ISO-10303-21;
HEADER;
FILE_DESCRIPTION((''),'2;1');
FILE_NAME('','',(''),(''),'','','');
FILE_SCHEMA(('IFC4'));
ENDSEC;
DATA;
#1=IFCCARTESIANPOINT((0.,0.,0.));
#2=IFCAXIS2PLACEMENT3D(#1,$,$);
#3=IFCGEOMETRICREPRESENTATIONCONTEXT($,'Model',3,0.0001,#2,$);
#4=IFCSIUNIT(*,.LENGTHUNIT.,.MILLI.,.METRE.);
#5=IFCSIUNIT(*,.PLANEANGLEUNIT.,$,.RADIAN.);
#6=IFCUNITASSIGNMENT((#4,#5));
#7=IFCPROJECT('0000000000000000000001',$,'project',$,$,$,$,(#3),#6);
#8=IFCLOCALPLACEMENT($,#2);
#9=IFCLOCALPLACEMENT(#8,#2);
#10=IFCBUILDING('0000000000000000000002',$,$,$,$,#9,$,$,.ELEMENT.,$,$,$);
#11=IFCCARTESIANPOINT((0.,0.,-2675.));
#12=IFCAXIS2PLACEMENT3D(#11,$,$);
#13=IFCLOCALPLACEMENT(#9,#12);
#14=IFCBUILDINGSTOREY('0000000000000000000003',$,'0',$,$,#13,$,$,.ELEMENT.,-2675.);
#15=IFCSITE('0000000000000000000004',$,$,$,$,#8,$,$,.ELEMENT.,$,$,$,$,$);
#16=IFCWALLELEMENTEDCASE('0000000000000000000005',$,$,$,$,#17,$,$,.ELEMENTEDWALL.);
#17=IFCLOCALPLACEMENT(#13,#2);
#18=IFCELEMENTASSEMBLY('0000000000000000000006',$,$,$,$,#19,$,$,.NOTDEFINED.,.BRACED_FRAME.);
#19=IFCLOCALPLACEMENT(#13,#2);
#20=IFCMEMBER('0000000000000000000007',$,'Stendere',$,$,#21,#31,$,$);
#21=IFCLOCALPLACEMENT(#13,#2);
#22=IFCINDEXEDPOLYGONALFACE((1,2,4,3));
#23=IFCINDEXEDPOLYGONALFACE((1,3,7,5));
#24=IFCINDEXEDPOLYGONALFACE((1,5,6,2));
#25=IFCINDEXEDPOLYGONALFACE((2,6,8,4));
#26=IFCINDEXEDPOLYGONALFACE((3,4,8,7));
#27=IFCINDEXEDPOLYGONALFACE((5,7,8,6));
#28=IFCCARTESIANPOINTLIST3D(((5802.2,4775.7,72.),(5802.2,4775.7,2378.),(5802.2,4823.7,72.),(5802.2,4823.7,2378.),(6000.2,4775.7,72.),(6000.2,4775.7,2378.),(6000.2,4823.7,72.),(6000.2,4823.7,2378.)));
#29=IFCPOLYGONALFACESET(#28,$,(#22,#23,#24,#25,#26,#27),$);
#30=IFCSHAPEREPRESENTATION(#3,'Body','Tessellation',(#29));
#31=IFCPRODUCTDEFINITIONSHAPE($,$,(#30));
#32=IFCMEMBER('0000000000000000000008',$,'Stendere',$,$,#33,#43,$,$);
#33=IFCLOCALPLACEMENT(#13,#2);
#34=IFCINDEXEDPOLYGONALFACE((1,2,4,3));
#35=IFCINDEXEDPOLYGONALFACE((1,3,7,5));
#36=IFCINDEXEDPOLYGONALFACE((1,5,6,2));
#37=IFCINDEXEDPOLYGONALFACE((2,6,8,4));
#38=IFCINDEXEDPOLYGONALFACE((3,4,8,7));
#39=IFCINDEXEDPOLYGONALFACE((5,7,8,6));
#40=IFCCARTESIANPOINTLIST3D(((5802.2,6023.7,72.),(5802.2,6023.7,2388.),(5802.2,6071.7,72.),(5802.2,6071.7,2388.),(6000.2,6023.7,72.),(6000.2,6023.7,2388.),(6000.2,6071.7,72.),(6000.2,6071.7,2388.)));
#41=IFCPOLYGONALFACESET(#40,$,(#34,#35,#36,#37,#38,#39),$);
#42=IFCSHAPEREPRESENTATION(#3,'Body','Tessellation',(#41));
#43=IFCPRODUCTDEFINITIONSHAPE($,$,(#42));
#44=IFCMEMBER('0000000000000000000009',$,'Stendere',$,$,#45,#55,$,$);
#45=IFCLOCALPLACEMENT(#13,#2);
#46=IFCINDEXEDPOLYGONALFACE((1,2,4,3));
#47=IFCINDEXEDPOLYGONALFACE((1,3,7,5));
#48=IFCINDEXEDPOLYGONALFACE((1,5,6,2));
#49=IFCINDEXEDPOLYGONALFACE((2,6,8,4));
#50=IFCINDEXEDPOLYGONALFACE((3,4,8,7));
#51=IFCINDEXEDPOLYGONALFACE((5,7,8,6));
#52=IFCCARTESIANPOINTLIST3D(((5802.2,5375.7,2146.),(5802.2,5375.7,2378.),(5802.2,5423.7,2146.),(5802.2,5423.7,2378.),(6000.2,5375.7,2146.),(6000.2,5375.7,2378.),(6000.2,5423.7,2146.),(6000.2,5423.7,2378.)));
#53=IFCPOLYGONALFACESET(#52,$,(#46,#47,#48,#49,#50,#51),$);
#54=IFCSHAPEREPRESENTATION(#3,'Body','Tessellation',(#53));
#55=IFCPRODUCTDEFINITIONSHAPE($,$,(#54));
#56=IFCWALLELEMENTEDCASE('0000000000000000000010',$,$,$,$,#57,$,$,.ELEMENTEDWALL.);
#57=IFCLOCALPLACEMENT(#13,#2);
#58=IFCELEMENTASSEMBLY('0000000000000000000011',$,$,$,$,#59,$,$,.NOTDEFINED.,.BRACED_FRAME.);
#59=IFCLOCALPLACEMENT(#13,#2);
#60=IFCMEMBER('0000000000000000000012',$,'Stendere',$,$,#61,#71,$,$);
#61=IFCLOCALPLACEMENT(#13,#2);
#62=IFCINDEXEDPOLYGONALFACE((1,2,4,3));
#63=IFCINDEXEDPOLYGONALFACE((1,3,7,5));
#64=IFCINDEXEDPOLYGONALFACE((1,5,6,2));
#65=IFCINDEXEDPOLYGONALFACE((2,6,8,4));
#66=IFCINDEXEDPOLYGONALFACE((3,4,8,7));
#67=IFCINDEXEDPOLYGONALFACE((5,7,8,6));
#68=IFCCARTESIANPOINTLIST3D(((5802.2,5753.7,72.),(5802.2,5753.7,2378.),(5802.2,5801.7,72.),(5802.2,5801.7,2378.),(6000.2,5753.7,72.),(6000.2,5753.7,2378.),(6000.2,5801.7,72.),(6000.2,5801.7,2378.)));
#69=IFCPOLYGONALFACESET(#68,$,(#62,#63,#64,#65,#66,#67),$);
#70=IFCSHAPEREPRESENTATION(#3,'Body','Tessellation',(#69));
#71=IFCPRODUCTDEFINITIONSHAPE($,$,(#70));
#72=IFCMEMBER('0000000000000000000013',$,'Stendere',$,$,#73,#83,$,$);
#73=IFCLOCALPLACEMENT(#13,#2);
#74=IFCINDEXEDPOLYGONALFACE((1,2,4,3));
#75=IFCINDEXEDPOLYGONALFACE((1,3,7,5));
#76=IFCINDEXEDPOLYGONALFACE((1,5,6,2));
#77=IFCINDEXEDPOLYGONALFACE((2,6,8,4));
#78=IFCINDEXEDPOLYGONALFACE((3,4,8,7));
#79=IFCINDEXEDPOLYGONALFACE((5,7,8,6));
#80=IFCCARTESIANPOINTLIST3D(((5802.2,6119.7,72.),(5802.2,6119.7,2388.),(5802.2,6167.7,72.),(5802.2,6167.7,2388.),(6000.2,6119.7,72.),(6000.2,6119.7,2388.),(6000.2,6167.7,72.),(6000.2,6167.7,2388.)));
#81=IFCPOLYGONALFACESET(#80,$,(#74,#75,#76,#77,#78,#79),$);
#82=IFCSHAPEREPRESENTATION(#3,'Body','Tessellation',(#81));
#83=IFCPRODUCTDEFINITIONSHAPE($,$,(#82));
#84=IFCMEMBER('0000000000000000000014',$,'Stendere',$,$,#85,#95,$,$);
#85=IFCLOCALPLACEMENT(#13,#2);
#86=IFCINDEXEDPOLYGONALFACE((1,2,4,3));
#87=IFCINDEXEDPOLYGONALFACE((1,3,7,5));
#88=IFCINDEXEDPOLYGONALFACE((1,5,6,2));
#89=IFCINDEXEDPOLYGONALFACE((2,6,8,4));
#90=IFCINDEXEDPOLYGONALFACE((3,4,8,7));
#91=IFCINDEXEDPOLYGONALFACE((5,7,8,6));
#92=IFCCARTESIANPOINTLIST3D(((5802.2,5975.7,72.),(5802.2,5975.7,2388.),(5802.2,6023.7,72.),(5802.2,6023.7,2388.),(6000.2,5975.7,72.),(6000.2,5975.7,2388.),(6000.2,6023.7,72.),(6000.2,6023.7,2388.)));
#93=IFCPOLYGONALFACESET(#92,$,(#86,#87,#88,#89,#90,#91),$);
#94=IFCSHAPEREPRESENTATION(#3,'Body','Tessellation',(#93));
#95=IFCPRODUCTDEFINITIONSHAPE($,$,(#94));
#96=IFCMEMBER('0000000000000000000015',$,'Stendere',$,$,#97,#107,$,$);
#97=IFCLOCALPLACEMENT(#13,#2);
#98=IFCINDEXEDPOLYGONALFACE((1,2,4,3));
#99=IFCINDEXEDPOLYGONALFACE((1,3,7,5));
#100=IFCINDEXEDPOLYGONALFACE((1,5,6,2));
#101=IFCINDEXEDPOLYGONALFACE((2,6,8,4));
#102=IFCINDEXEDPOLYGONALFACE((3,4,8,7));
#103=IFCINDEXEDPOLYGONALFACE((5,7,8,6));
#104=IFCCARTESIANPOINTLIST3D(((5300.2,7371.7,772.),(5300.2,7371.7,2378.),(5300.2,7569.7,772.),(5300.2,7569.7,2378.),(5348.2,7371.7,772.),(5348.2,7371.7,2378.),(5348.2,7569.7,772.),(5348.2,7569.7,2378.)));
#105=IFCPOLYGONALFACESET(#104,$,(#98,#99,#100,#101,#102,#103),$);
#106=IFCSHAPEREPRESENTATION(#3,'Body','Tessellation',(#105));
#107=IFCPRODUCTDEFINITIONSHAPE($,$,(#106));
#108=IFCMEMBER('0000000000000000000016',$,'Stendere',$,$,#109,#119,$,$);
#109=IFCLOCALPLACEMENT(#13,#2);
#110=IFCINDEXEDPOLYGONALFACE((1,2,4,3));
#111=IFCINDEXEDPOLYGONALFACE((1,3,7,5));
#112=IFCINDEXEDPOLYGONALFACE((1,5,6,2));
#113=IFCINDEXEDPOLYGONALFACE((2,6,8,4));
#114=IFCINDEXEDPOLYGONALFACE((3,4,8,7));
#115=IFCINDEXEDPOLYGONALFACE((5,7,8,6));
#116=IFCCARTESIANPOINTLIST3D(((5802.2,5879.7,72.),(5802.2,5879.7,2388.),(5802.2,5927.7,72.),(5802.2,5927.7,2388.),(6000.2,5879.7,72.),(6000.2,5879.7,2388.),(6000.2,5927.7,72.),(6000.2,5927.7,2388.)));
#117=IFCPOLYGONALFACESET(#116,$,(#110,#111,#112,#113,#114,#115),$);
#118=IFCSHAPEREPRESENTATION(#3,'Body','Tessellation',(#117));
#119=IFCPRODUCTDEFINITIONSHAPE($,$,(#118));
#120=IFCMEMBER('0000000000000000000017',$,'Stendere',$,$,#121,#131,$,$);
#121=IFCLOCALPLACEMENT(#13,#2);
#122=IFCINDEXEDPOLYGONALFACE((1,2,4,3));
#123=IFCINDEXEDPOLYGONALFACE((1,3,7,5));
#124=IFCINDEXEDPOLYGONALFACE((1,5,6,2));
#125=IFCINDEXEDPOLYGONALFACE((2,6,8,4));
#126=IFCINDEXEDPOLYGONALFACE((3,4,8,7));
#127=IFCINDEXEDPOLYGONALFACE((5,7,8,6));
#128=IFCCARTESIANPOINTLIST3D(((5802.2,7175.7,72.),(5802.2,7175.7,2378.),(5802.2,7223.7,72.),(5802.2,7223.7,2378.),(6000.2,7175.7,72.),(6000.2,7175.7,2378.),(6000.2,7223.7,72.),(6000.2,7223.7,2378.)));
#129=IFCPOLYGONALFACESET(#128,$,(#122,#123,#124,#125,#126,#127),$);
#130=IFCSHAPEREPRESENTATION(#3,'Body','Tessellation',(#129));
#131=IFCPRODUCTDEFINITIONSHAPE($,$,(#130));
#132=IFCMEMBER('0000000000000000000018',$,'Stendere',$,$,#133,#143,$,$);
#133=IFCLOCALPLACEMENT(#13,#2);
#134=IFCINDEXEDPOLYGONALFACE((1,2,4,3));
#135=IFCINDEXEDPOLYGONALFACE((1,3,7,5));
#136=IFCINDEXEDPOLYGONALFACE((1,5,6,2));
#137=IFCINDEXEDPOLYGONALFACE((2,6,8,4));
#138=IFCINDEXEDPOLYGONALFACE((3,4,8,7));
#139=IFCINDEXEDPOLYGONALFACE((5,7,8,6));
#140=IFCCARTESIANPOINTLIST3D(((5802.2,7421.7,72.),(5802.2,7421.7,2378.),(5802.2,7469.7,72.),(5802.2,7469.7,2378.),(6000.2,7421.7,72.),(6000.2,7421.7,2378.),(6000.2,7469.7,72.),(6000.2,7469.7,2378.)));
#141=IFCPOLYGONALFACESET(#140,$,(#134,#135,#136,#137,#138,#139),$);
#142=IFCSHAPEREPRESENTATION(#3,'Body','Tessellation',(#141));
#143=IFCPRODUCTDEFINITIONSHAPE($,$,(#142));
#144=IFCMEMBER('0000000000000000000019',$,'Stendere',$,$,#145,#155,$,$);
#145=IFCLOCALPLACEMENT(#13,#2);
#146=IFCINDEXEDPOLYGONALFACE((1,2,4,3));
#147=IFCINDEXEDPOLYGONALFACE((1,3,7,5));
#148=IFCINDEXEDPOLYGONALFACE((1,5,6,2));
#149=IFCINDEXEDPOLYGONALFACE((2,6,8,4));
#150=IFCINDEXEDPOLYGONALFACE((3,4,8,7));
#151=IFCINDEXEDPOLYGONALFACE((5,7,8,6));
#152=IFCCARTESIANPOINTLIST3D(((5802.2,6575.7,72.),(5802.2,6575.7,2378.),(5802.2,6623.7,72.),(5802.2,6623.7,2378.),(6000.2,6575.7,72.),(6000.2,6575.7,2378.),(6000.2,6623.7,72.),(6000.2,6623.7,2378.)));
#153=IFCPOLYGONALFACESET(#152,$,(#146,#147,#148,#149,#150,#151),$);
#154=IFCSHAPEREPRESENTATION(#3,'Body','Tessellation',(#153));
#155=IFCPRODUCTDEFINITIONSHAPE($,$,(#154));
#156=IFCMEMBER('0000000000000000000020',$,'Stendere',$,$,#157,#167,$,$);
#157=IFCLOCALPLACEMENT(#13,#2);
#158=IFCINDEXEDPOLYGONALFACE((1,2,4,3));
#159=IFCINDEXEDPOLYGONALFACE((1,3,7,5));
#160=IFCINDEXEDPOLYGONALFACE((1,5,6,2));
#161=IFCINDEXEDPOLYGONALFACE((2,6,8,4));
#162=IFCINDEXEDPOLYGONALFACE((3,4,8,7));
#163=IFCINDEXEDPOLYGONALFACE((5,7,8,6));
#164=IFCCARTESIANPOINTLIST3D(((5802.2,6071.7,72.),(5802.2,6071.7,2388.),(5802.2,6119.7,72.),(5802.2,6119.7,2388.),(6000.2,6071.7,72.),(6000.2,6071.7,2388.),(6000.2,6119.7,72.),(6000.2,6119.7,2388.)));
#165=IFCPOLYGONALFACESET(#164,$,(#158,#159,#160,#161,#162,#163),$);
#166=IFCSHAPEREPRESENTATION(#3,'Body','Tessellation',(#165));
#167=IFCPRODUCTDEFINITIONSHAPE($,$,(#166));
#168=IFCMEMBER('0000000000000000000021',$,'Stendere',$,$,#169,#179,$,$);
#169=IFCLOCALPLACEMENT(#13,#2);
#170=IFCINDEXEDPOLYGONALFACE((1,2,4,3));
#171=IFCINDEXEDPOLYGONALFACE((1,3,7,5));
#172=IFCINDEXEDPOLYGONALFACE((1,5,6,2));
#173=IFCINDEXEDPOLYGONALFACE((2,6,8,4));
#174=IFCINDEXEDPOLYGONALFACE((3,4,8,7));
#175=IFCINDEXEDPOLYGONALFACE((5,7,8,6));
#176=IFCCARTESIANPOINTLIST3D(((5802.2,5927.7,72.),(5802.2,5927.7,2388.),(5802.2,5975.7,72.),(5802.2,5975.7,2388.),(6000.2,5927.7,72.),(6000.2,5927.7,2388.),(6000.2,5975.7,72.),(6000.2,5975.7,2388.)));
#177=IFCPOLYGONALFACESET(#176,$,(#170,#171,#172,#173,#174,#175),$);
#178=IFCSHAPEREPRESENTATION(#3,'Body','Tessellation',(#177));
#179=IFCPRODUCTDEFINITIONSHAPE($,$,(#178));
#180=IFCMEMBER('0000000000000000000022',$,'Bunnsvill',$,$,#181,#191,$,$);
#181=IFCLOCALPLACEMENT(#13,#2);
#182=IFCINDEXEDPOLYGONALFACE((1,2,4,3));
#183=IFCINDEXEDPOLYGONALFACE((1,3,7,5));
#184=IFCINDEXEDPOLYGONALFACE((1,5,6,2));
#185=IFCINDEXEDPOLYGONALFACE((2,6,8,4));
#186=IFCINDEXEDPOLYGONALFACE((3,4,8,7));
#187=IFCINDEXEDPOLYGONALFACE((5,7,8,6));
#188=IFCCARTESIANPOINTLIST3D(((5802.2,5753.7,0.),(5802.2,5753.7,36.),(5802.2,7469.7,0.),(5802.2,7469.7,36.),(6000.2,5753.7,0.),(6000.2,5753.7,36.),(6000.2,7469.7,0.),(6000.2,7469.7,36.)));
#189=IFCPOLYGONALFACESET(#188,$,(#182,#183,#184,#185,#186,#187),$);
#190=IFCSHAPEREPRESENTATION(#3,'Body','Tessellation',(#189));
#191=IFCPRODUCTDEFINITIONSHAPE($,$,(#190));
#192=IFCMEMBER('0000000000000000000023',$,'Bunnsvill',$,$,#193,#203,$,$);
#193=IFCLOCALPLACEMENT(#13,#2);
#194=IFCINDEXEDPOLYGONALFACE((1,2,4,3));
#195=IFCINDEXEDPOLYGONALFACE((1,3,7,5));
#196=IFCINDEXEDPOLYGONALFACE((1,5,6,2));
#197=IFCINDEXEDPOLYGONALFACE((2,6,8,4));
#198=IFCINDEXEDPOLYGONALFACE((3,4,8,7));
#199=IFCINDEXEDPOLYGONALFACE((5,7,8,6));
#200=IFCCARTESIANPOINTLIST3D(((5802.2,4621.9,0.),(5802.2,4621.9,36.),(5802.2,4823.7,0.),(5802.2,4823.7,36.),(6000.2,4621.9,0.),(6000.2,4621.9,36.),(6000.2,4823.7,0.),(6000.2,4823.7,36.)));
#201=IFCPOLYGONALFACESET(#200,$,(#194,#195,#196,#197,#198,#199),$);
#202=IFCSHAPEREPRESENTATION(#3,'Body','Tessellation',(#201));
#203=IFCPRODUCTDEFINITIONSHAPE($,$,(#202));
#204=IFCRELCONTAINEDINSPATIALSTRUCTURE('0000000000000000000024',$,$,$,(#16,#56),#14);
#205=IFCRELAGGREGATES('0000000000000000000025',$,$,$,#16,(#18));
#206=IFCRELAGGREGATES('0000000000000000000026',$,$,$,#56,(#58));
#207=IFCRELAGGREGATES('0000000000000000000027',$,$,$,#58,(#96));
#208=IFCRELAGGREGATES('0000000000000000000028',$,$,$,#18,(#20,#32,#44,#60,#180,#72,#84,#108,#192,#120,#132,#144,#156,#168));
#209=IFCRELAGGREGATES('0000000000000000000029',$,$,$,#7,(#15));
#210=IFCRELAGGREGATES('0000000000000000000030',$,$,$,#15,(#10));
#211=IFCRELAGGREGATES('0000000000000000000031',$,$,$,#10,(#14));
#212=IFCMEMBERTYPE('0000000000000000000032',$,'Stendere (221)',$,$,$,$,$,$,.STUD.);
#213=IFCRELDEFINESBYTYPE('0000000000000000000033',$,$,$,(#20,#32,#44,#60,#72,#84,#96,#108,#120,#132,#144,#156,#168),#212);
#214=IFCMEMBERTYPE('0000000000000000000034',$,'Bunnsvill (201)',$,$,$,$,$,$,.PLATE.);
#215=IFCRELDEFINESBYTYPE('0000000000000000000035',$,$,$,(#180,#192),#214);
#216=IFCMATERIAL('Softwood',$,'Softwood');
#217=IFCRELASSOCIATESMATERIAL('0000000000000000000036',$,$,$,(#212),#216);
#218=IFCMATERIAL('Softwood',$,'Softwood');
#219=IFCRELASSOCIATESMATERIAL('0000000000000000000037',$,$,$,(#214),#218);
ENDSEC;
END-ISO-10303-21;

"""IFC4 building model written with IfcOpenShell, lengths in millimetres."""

from ifc_helpers import new_model, si_unit, frame, origin, place, context, project, spatial, rectangle, extrude, clip, halfspace, material, material_profile, profile_set, type_object, element, aggregate, save


model = new_model("IFC4")

# Units and contexts
model_context = context("Model", 3, precision=0.0001, world=origin())
ifc_project = project(units=[si_unit("LENGTHUNIT", "METRE", prefix="MILLI"), si_unit("PLANEANGLEUNIT", "RADIAN")], contexts=[model_context])

# Site, building, storey
site_placement = place(None, origin())
site = spatial("IfcSite", under=ifc_project, at=site_placement, CompositionType="ELEMENT")
building_placement = place(site_placement, origin())
building = spatial("IfcBuilding", under=site, at=building_placement, CompositionType="ELEMENT")
storey_placement = place(building_placement, frame((0.0, 0.0, -2675.0)))
storey = spatial("IfcBuildingStorey", under=building, at=storey_placement, Name="0", CompositionType="ELEMENT", Elevation=-2675.0)

# Wall, element assembly, members
wall_1_placement = place(storey_placement, frame((6000.2, 7469.7, 0.0), z_axis=(-1.0, 0.0, 0.0), x_axis=(0.0, -1.0, 0.0)))
wall_1 = element("IfcWallElementedCase", 1, at=wall_1_placement, inside=storey, PredefinedType="ELEMENTEDWALL")
assembly_1_placement = place(wall_1_placement, origin())
assembly_1 = element("IfcElementAssembly", 2, at=assembly_1_placement, AssemblyPlace="NOTDEFINED", PredefinedType="BRACED_FRAME")
aggregate(wall_1, [assembly_1])
ifc_material_1 = material(Name="Softwood", Category="Softwood")
ifc_material_profile_1 = material_profile(ifc_material_1, rectangle(XDim=48.0, YDim=198.0), Name="Stendere (221)")
ifc_profile_set_1 = profile_set([ifc_material_profile_1])
member_type_1 = type_object("IfcMemberType", Name="Stendere (221)", PredefinedType="STUD", material=ifc_profile_set_1)
member_1_placement = place(assembly_1_placement, frame((2670.0, 72.0, 0.0), z_axis=(0.0, 1.0, 0.0), x_axis=(-1.0, 0.0, 0.0)))
member_1 = element("IfcMember", 3, at=member_1_placement, type_object=member_type_1, Name="Stendere", context=model_context, shape_type="SweptSolid", body=[
    extrude(rectangle(XDim=48.0, YDim=198.0), frame((0.0, 99.0, 0.0)), (0.0, 0.0, 1.0), 2306.0),
])
member_2_placement = place(assembly_1_placement, frame((1422.0, 72.0, 0.0), z_axis=(0.0, 1.0, 0.0), x_axis=(-1.0, 0.0, 0.0)))
member_2 = element("IfcMember", 4, at=member_2_placement, type_object=member_type_1, Name="Stendere", context=model_context, shape_type="SweptSolid", body=[
    extrude(rectangle(XDim=48.0, YDim=198.0), frame((0.0, 99.0, 0.0)), (0.0, 0.0, 1.0), 2316.0),
])
member_3_placement = place(assembly_1_placement, frame((2070.0, 2146.0, 0.0), z_axis=(0.0, 1.0, 0.0), x_axis=(-1.0, 0.0, 0.0)))
member_3 = element("IfcMember", 5, at=member_3_placement, type_object=member_type_1, Name="Stendere", context=model_context, shape_type="SweptSolid", body=[
    extrude(rectangle(XDim=48.0, YDim=198.0), frame((0.0, 99.0, 0.0)), (0.0, 0.0, 1.0), 232.0),
])

# Wall, element assembly
wall_2_placement = place(storey_placement, frame((5348.2, 7371.7, 700.0), z_axis=(0.0, 1.0, 0.0), x_axis=(-1.0, 0.0, 0.0)))
wall_2 = element("IfcWallElementedCase", 6, at=wall_2_placement, inside=storey, PredefinedType="ELEMENTEDWALL")
assembly_2_placement = place(wall_2_placement, origin())
assembly_2 = element("IfcElementAssembly", 7, at=assembly_2_placement, AssemblyPlace="NOTDEFINED", PredefinedType="BRACED_FRAME")
aggregate(wall_2, [assembly_2])

# Members
member_4_placement = place(assembly_1_placement, frame((1692.0, 72.0, 0.0), z_axis=(0.0, 1.0, 0.0), x_axis=(-1.0, 0.0, 0.0)))
member_4 = element("IfcMember", 8, at=member_4_placement, type_object=member_type_1, Name="Stendere", context=model_context, shape_type="SweptSolid", body=[
    extrude(rectangle(XDim=48.0, YDim=198.0), frame((0.0, 99.0, 0.0)), (0.0, 0.0, 1.0), 2306.0),
])
member_5_placement = place(assembly_1_placement, frame((1326.0, 72.0, 0.0), z_axis=(0.0, 1.0, 0.0), x_axis=(-1.0, 0.0, 0.0)))
member_5 = element("IfcMember", 9, at=member_5_placement, type_object=member_type_1, Name="Stendere", context=model_context, shape_type="SweptSolid", body=[
    extrude(rectangle(XDim=48.0, YDim=198.0), frame((0.0, 99.0, 0.0)), (0.0, 0.0, 1.0), 2316.0),
])
member_6_placement = place(assembly_1_placement, frame((1470.0, 72.0, 0.0), z_axis=(0.0, 1.0, 0.0), x_axis=(-1.0, 0.0, 0.0)))
member_6 = element("IfcMember", 10, at=member_6_placement, type_object=member_type_1, Name="Stendere", context=model_context, shape_type="SweptSolid", body=[
    extrude(rectangle(XDim=48.0, YDim=198.0), frame((0.0, 99.0, 0.0)), (0.0, 0.0, 1.0), 2316.0),
])
member_7_placement = place(assembly_2_placement, frame((24.0, 72.0, 0.0), z_axis=(0.0, 1.0, 0.0), x_axis=(-1.0, 0.0, 0.0)))
member_7 = element("IfcMember", 11, at=member_7_placement, type_object=member_type_1, Name="Stendere", context=model_context, shape_type="SweptSolid", body=[
    extrude(rectangle(XDim=48.0, YDim=198.0), frame((0.0, 99.0, 0.0)), (0.0, 0.0, 1.0), 1606.0),
])
member_8_placement = place(assembly_1_placement, frame((1566.0, 72.0, 0.0), z_axis=(0.0, 1.0, 0.0), x_axis=(-1.0, 0.0, 0.0)))
member_8 = element("IfcMember", 12, at=member_8_placement, type_object=member_type_1, Name="Stendere", context=model_context, shape_type="SweptSolid", body=[
    extrude(rectangle(XDim=48.0, YDim=198.0), frame((0.0, 99.0, 0.0)), (0.0, 0.0, 1.0), 2316.0),
])
member_9_placement = place(assembly_1_placement, frame((270.0, 72.0, 0.0), z_axis=(0.0, 1.0, 0.0), x_axis=(-1.0, 0.0, 0.0)))
member_9 = element("IfcMember", 13, at=member_9_placement, type_object=member_type_1, Name="Stendere", context=model_context, shape_type="SweptSolid", body=[
    extrude(rectangle(XDim=48.0, YDim=198.0), frame((0.0, 99.0, 0.0)), (0.0, 0.0, 1.0), 2306.0),
])
member_10_placement = place(assembly_1_placement, frame((24.0, 72.0, 0.0), z_axis=(0.0, 1.0, 0.0), x_axis=(-1.0, 0.0, 0.0)))
member_10 = element("IfcMember", 14, at=member_10_placement, type_object=member_type_1, Name="Stendere", context=model_context, shape_type="SweptSolid", body=[
    extrude(rectangle(XDim=48.0, YDim=198.0), frame((0.0, 99.0, 0.0)), (0.0, 0.0, 1.0), 2306.0),
])
member_11_placement = place(assembly_1_placement, frame((870.0, 72.0, 0.0), z_axis=(0.0, 1.0, 0.0), x_axis=(-1.0, 0.0, 0.0)))
member_11 = element("IfcMember", 15, at=member_11_placement, type_object=member_type_1, Name="Stendere", context=model_context, shape_type="SweptSolid", body=[
    extrude(rectangle(XDim=48.0, YDim=198.0), frame((0.0, 99.0, 0.0)), (0.0, 0.0, 1.0), 2306.0),
])
member_12_placement = place(assembly_1_placement, frame((1374.0, 72.0, 0.0), z_axis=(0.0, 1.0, 0.0), x_axis=(-1.0, 0.0, 0.0)))
member_12 = element("IfcMember", 16, at=member_12_placement, type_object=member_type_1, Name="Stendere", context=model_context, shape_type="Clipping", body=[
    clip(extrude(rectangle(XDim=48.0, YDim=198.0), frame((0.0, 99.0, 0.0)), (0.0, 0.0, 1.0), 2316.0), halfspace(frame((0.0, 99.0, 0.0)), True)),
])
member_13_placement = place(assembly_1_placement, frame((1518.0, 72.0, 0.0), z_axis=(0.0, 1.0, 0.0), x_axis=(-1.0, 0.0, 0.0)))
member_13 = element("IfcMember", 17, at=member_13_placement, type_object=member_type_1, Name="Stendere", context=model_context, shape_type="SweptSolid", body=[
    extrude(rectangle(XDim=48.0, YDim=198.0), frame((0.0, 99.0, 0.0)), (0.0, 0.0, 1.0), 2316.0),
])
ifc_material_2 = material(Name="Softwood", Category="Softwood")
ifc_material_profile_2 = material_profile(ifc_material_2, rectangle(XDim=36.0, YDim=198.0), Name="Bunnsvill (201)")
ifc_profile_set_2 = profile_set([ifc_material_profile_2])
member_type_2 = type_object("IfcMemberType", Name="Bunnsvill (201)", PredefinedType="PLATE", material=ifc_profile_set_2)
member_14_placement = place(assembly_1_placement, frame((0.0, 18.0, 0.0), z_axis=(1.0, 0.0, 0.0), x_axis=(0.0, 1.0, 0.0)))
member_14 = element("IfcMember", 18, at=member_14_placement, type_object=member_type_2, Name="Bunnsvill", context=model_context, shape_type="SweptSolid", body=[
    extrude(rectangle(XDim=36.0, YDim=198.0), frame((0.0, 99.0, 0.0)), (0.0, 0.0, 1.0), 1716.0),
])
member_15_placement = place(assembly_1_placement, frame((2646.0, 18.0, 0.0), z_axis=(1.0, 0.0, 0.0), x_axis=(0.0, 1.0, 0.0)))
member_15 = element("IfcMember", 19, at=member_15_placement, type_object=member_type_2, Name="Bunnsvill", context=model_context, shape_type="SweptSolid", body=[
    extrude(rectangle(XDim=36.0, YDim=198.0), frame((0.0, 99.0, 0.0)), (0.0, 0.0, 1.0), 201.8),
])

aggregate(assembly_2, [member_7])

aggregate(assembly_1, [member_1, member_2, member_3, member_4, member_14, member_5, member_6, member_8, member_15, member_9, member_10, member_11, member_12, member_13])

save(model, "model.ifc")
